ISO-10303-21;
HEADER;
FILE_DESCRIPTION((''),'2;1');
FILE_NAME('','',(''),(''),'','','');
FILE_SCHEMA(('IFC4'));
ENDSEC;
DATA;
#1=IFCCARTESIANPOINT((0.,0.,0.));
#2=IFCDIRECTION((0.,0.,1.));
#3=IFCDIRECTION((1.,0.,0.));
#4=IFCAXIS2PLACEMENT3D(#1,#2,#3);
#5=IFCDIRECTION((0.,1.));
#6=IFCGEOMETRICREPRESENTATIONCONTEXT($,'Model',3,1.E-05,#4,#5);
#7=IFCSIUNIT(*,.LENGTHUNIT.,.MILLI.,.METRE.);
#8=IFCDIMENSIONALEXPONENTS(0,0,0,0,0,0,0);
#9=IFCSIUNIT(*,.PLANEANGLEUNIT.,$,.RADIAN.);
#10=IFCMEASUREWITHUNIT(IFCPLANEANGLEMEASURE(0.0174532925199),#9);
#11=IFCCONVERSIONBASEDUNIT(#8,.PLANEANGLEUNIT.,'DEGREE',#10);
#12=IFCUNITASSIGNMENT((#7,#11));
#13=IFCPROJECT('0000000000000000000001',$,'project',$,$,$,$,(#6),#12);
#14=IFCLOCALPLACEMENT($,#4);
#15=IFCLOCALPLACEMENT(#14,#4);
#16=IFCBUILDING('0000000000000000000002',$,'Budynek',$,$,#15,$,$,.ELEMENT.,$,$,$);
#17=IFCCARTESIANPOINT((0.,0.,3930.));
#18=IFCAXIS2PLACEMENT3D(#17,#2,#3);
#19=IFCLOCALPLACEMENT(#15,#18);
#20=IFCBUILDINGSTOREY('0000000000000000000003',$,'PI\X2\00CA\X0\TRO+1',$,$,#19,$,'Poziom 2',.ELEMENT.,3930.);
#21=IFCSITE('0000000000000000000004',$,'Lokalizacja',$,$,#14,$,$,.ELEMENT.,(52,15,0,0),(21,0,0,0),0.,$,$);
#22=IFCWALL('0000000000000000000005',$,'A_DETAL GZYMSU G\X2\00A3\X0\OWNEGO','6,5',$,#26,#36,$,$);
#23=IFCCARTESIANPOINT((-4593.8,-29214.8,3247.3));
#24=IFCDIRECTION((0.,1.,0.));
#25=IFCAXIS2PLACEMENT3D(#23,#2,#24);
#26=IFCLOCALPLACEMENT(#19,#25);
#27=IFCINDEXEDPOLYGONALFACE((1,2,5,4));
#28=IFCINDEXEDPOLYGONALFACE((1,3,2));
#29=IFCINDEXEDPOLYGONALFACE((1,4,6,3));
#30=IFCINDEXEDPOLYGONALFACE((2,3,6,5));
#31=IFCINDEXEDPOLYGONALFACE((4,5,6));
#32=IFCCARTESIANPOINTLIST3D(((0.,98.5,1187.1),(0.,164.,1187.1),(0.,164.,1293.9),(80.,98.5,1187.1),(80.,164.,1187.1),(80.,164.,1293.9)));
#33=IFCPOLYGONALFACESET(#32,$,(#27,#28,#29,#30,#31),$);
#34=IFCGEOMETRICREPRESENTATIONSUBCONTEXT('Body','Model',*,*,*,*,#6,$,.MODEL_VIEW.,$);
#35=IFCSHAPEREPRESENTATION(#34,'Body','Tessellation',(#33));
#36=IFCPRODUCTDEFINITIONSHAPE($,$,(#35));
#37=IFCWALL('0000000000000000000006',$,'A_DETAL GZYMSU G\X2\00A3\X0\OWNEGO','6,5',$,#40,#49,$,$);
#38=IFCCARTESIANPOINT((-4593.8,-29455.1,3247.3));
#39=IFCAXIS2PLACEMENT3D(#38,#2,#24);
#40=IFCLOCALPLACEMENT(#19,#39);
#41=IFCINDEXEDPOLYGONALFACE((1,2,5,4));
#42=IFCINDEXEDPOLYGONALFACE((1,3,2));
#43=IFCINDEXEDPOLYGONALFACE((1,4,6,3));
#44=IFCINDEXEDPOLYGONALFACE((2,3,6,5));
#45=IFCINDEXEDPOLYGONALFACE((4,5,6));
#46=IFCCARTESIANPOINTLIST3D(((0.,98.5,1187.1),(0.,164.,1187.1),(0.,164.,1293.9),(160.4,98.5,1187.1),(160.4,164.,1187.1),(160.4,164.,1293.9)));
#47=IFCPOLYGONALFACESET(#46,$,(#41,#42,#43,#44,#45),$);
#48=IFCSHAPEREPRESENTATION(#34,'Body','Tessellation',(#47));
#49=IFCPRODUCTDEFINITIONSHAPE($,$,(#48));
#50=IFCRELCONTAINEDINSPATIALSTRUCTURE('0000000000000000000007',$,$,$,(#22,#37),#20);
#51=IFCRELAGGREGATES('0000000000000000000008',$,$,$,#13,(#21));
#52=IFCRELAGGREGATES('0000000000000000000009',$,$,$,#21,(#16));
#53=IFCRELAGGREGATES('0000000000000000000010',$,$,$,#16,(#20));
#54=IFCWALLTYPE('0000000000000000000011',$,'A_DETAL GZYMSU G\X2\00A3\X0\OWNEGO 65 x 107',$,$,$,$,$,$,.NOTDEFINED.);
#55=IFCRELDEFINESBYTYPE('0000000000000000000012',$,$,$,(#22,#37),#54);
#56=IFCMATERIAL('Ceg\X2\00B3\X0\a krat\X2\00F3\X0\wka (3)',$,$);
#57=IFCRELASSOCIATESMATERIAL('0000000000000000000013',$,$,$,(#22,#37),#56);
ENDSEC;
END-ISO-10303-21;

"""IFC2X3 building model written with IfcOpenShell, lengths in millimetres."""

from ifc_helpers import new_model, entity, si_unit, converted_unit, direction, frame, origin_with_axes, place, context, subcontext, project, spatial, polyline, outline, extrude, material, type_object, element, save


model = new_model("IFC2X3")

# Units and contexts
model_context = context("Model", 3, precision=1e-05, world=origin_with_axes(), true_north=direction((0.0, 1.0)))
body_context = subcontext(model_context, "Body", "Model", "MODEL_VIEW")
ifc_project = project(units=[si_unit("LENGTHUNIT", "METRE", prefix="MILLI"), converted_unit("PLANEANGLEUNIT", "DEGREE", entity("IfcPlaneAngleMeasure", 0.0174532925199), si_unit("PLANEANGLEUNIT", "RADIAN"), dimensions=[0, 0, 0, 0, 0, 0, 0])], contexts=[model_context])

# Site, building, storey
site_placement = place(None, origin_with_axes())
site = spatial("IfcSite", under=ifc_project, at=site_placement, Name="Lokalizacja", CompositionType="ELEMENT", RefLatitude=(52, 15, 0, 0), RefLongitude=(21, 0, 0, 0), RefElevation=0.0)
building_placement = place(site_placement, origin_with_axes())
building = spatial("IfcBuilding", under=site, at=building_placement, Name="Budynek", CompositionType="ELEMENT")
storey_placement = place(building_placement, frame((0.0, 0.0, 3930.0), z_axis=(0.0, 0.0, 1.0), x_axis=(1.0, 0.0, 0.0)))
storey = spatial("IfcBuildingStorey", under=building, at=storey_placement, Name="PIÊTRO+1", LongName="Poziom 2", CompositionType="ELEMENT", Elevation=3930.0)

# Walls
ifc_material_1 = material(Name="Ceg³a kratówka (3)")
wall_type_1 = type_object("IfcWallType", Name="A_DETAL GZYMSU G£OWNEGO 65 x 107", PredefinedType="NOTDEFINED")
wall_1_placement = place(storey_placement, frame((-4593.8, -29214.8, 3247.3), z_axis=(0.0, 0.0, 1.0), x_axis=(0.0, 1.0, 0.0)))
element("IfcWall", 1, at=wall_1_placement, inside=storey, type_object=wall_type_1, material=ifc_material_1, Name="A_DETAL GZYMSU G£OWNEGO", Description="6,5", context=body_context, shape_type="SweptSolid", body=[
    extrude(outline(polyline([(-164.0, 1293.9), (-164.0, 1187.1), (-98.5, 1187.1), (-164.0, 1293.9)])), frame((0.0, 0.0, 0.0), z_axis=(-1.0, 0.0, 0.0), x_axis=(0.0, -1.0, 0.0)), (0.0, 0.0, -1.0), 80.0),
])
wall_2_placement = place(storey_placement, frame((-4593.8, -29455.1, 3247.3), z_axis=(0.0, 0.0, 1.0), x_axis=(0.0, 1.0, 0.0)))
element("IfcWall", 2, at=wall_2_placement, inside=storey, type_object=wall_type_1, material=ifc_material_1, Name="A_DETAL GZYMSU G£OWNEGO", Description="6,5", context=body_context, shape_type="SweptSolid", body=[
    extrude(outline(polyline([(-164.0, 1293.9), (-164.0, 1187.1), (-98.5, 1187.1), (-164.0, 1293.9)])), frame((0.0, 0.0, 0.0), z_axis=(-1.0, 0.0, 0.0), x_axis=(0.0, -1.0, 0.0)), (0.0, 0.0, -1.0), 160.4),
])

save(model, "model.ifc")
